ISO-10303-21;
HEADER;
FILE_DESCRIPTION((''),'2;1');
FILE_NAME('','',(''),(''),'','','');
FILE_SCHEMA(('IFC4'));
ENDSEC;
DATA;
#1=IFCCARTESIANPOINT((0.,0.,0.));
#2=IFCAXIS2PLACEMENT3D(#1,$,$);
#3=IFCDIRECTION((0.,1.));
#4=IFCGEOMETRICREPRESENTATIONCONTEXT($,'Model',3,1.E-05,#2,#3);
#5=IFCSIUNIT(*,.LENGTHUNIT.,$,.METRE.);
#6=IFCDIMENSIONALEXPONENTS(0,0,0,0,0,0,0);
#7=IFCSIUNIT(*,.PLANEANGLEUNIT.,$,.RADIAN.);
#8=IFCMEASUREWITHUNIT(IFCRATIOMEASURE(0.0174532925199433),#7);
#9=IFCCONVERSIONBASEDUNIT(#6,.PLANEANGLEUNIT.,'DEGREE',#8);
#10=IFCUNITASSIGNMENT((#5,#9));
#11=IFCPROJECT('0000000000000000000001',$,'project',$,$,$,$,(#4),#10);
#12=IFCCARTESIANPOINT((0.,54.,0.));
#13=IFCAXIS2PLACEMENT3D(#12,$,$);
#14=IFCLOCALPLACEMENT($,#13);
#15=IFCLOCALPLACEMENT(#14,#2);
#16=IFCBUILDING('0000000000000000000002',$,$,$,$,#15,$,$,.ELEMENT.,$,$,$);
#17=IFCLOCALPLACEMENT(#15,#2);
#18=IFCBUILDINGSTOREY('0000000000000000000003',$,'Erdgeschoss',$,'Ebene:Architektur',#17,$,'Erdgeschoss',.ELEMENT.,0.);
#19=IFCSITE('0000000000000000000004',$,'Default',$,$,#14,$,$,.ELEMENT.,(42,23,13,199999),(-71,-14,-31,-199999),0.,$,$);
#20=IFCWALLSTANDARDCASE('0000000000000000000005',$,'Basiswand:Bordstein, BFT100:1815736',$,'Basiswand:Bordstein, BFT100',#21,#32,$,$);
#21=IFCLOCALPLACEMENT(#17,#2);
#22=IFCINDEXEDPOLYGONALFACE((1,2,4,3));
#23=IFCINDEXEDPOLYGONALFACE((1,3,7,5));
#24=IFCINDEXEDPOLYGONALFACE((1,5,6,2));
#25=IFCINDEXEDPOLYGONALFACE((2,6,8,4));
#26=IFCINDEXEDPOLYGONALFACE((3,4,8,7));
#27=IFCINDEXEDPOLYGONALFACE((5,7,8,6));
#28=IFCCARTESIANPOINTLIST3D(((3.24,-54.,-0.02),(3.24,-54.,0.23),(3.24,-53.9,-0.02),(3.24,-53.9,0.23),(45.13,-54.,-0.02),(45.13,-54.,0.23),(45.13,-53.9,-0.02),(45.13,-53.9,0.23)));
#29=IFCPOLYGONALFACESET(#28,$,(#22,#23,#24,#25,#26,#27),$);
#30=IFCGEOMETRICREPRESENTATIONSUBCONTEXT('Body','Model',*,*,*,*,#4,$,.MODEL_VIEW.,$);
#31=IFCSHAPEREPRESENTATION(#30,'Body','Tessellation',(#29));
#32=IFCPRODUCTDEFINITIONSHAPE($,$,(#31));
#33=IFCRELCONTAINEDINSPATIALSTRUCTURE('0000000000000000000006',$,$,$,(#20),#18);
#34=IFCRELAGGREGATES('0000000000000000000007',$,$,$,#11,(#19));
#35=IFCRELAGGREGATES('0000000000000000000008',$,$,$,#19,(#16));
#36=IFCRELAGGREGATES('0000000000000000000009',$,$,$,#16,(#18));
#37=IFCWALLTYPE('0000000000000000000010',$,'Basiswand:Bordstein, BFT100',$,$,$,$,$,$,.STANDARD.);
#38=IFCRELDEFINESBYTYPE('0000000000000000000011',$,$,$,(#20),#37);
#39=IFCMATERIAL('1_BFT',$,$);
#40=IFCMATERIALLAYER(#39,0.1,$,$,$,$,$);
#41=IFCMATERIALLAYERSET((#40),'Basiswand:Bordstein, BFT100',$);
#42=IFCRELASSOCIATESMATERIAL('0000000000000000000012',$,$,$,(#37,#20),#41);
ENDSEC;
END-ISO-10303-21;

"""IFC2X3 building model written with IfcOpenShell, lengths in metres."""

from ifc_helpers import new_model, entity, si_unit, converted_unit, direction, frame, frame_2d, origin, place, context, subcontext, project, spatial, rectangle, extrude, material, layer, layer_set, layer_usage, type_object, element, save


model = new_model("IFC2X3")

# Units and contexts
model_context = context("Model", 3, precision=1e-05, world=origin(), true_north=direction((0.0, 1.0)))
body_context = subcontext(model_context, "Body", "Model", "MODEL_VIEW")
ifc_project = project(units=[si_unit("LENGTHUNIT", "METRE"), converted_unit("PLANEANGLEUNIT", "DEGREE", entity("IfcRatioMeasure", 0.0174532925199433), si_unit("PLANEANGLEUNIT", "RADIAN"), dimensions=[0, 0, 0, 0, 0, 0, 0])], contexts=[model_context])

# Site, building, storey
site_placement = place(None, frame((0.0, 54.0, 0.0)))
site = spatial("IfcSite", under=ifc_project, at=site_placement, Name="Default", CompositionType="ELEMENT", RefLatitude=(42, 23, 13, 199999), RefLongitude=(-71, -14, -31, -199999), RefElevation=0.0)
building_placement = place(site_placement, origin())
building = spatial("IfcBuilding", under=site, at=building_placement, CompositionType="ELEMENT")
storey_placement = place(building_placement, origin())
storey = spatial("IfcBuildingStorey", under=building, at=storey_placement, Name="Erdgeschoss", ObjectType="Ebene:Architektur", LongName="Erdgeschoss", CompositionType="ELEMENT", Elevation=0.0)

# Wall
ifc_material_1 = material(Name="1_BFT")
ifc_layer_1 = layer(ifc_material_1, 0.1)
ifc_layer_set_1 = layer_set([ifc_layer_1], Name="Basiswand:Bordstein, BFT100")
ifc_layer_usage_1 = layer_usage(ifc_layer_set_1, "AXIS2", "POSITIVE", -0.05)
wall_type = type_object("IfcWallType", Name="Basiswand:Bordstein, BFT100", PredefinedType="STANDARD", material=ifc_layer_set_1)
wall_placement = place(storey_placement, frame((3.24, -53.95, -0.02)))
element("IfcWallStandardCase", 1, at=wall_placement, inside=storey, type_object=wall_type, material=ifc_layer_usage_1, Name="Basiswand:Bordstein, BFT100:1815736", ObjectType="Basiswand:Bordstein, BFT100", context=body_context, shape_type="SweptSolid", body=[
    extrude(rectangle(XDim=41.89, YDim=0.1, at=frame_2d((20.945, 0.0), x_axis=(-1.0, 0.0))), origin(), (0.0, 0.0, 1.0), 0.25),
])

save(model, "model.ifc")
